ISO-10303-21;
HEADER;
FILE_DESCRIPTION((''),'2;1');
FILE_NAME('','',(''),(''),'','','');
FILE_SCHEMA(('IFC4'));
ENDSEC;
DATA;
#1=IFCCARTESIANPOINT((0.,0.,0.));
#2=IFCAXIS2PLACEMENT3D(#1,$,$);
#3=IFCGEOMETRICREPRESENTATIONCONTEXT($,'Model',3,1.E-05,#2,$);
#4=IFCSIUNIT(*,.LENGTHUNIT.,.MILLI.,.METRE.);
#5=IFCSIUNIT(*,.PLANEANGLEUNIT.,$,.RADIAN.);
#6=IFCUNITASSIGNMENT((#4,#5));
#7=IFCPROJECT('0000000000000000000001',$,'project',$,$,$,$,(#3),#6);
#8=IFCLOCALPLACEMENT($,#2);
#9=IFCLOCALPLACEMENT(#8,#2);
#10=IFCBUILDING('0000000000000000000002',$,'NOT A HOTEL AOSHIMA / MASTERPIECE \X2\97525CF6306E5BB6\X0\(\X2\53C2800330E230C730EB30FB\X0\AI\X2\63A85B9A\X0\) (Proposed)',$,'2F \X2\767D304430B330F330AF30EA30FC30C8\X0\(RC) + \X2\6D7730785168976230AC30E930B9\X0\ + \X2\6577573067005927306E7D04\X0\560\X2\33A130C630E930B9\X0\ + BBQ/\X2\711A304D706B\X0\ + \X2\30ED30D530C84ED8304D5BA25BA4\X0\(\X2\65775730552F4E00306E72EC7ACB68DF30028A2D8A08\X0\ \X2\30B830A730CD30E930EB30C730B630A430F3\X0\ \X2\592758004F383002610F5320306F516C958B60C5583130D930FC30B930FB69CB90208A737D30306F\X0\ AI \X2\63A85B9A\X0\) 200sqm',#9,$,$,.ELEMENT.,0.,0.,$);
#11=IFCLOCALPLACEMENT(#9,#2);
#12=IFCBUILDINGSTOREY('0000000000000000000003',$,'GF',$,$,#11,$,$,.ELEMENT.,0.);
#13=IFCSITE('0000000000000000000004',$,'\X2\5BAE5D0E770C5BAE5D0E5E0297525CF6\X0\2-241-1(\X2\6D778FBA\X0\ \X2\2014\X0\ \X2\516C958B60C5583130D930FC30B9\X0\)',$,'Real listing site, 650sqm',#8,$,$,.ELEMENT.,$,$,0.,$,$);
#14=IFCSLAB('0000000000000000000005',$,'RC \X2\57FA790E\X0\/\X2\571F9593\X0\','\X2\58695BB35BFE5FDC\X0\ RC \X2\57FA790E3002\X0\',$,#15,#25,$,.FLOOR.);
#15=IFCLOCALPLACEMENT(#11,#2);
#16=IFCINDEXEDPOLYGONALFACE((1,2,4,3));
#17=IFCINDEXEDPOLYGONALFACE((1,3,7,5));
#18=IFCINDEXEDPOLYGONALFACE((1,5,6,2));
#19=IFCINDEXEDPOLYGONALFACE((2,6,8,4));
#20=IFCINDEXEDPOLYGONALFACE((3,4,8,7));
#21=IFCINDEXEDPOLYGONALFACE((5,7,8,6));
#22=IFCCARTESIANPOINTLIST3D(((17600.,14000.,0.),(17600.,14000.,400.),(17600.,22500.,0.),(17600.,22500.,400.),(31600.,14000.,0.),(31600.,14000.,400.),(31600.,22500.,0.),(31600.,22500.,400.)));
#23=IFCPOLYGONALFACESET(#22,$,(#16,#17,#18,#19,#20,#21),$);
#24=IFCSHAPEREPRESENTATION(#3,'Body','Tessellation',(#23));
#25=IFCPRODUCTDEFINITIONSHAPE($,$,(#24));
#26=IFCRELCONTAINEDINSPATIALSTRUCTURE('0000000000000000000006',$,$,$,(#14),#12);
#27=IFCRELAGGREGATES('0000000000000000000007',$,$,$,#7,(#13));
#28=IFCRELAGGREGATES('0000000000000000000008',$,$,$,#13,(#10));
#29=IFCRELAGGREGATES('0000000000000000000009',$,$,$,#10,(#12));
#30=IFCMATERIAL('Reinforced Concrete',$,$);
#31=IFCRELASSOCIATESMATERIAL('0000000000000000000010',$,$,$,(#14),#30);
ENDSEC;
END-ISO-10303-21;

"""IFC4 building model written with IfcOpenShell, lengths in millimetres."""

from ifc_helpers import new_model, si_unit, frame, frame_2d, origin, place, context, project, spatial, rectangle, extrude, material, element, save


model = new_model("IFC4")

# Units and contexts
model_context = context("Model", 3, precision=1e-05, world=origin())
ifc_project = project(units=[si_unit("LENGTHUNIT", "METRE", prefix="MILLI"), si_unit("PLANEANGLEUNIT", "RADIAN")], contexts=[model_context])

# Site, building, storey
site_placement = place(None, origin())
site = spatial("IfcSite", under=ifc_project, at=site_placement, Name="宮崎県宮崎市青島2-241-1(海辺 — 公開情報ベース)", ObjectType="Real listing site, 650sqm", CompositionType="ELEMENT", RefElevation=0.0)
building_placement = place(site_placement, origin())
building = spatial("IfcBuilding", under=site, at=building_placement, Name="NOT A HOTEL AOSHIMA / MASTERPIECE 青島の家(参考モデル・AI推定) (Proposed)", ObjectType="2F 白いコンクリート(RC) + 海へ全面ガラス + 敷地最大の約560㎡テラス + BBQ/焚き火 + ロフト付き客室(敷地唯一の独立棟。設計 ジェネラルデザイン 大堀伸。意匠は公開情報ベース・構造詳細は AI 推定) 200sqm", CompositionType="ELEMENT", ElevationOfRefHeight=0.0, ElevationOfTerrain=0.0)
storey_placement = place(building_placement, origin())
storey = spatial("IfcBuildingStorey", under=building, at=storey_placement, Name="GF", CompositionType="ELEMENT", Elevation=0.0)

# Shared definitions
ifc_material_1 = material(Name="Reinforced Concrete")

# Slab
slab_1_placement = place(storey_placement, frame((8800.0, 7000.0, 0.0)))
element("IfcSlab", 1, at=slab_1_placement, inside=storey, material=ifc_material_1, Name="RC 基礎/土間", Description="塩害対応 RC 基礎。", PredefinedType="FLOOR", context=model_context, shape_type="SweptSolid", body=[
    extrude(rectangle(XDim=14000.0, YDim=8500.0, at=frame_2d((7000.0, 4250.0))), frame((8800.0, 7000.0, 0.0)), (0.0, 0.0, 1.0), 400.0),
])

save(model, "model.ifc")
